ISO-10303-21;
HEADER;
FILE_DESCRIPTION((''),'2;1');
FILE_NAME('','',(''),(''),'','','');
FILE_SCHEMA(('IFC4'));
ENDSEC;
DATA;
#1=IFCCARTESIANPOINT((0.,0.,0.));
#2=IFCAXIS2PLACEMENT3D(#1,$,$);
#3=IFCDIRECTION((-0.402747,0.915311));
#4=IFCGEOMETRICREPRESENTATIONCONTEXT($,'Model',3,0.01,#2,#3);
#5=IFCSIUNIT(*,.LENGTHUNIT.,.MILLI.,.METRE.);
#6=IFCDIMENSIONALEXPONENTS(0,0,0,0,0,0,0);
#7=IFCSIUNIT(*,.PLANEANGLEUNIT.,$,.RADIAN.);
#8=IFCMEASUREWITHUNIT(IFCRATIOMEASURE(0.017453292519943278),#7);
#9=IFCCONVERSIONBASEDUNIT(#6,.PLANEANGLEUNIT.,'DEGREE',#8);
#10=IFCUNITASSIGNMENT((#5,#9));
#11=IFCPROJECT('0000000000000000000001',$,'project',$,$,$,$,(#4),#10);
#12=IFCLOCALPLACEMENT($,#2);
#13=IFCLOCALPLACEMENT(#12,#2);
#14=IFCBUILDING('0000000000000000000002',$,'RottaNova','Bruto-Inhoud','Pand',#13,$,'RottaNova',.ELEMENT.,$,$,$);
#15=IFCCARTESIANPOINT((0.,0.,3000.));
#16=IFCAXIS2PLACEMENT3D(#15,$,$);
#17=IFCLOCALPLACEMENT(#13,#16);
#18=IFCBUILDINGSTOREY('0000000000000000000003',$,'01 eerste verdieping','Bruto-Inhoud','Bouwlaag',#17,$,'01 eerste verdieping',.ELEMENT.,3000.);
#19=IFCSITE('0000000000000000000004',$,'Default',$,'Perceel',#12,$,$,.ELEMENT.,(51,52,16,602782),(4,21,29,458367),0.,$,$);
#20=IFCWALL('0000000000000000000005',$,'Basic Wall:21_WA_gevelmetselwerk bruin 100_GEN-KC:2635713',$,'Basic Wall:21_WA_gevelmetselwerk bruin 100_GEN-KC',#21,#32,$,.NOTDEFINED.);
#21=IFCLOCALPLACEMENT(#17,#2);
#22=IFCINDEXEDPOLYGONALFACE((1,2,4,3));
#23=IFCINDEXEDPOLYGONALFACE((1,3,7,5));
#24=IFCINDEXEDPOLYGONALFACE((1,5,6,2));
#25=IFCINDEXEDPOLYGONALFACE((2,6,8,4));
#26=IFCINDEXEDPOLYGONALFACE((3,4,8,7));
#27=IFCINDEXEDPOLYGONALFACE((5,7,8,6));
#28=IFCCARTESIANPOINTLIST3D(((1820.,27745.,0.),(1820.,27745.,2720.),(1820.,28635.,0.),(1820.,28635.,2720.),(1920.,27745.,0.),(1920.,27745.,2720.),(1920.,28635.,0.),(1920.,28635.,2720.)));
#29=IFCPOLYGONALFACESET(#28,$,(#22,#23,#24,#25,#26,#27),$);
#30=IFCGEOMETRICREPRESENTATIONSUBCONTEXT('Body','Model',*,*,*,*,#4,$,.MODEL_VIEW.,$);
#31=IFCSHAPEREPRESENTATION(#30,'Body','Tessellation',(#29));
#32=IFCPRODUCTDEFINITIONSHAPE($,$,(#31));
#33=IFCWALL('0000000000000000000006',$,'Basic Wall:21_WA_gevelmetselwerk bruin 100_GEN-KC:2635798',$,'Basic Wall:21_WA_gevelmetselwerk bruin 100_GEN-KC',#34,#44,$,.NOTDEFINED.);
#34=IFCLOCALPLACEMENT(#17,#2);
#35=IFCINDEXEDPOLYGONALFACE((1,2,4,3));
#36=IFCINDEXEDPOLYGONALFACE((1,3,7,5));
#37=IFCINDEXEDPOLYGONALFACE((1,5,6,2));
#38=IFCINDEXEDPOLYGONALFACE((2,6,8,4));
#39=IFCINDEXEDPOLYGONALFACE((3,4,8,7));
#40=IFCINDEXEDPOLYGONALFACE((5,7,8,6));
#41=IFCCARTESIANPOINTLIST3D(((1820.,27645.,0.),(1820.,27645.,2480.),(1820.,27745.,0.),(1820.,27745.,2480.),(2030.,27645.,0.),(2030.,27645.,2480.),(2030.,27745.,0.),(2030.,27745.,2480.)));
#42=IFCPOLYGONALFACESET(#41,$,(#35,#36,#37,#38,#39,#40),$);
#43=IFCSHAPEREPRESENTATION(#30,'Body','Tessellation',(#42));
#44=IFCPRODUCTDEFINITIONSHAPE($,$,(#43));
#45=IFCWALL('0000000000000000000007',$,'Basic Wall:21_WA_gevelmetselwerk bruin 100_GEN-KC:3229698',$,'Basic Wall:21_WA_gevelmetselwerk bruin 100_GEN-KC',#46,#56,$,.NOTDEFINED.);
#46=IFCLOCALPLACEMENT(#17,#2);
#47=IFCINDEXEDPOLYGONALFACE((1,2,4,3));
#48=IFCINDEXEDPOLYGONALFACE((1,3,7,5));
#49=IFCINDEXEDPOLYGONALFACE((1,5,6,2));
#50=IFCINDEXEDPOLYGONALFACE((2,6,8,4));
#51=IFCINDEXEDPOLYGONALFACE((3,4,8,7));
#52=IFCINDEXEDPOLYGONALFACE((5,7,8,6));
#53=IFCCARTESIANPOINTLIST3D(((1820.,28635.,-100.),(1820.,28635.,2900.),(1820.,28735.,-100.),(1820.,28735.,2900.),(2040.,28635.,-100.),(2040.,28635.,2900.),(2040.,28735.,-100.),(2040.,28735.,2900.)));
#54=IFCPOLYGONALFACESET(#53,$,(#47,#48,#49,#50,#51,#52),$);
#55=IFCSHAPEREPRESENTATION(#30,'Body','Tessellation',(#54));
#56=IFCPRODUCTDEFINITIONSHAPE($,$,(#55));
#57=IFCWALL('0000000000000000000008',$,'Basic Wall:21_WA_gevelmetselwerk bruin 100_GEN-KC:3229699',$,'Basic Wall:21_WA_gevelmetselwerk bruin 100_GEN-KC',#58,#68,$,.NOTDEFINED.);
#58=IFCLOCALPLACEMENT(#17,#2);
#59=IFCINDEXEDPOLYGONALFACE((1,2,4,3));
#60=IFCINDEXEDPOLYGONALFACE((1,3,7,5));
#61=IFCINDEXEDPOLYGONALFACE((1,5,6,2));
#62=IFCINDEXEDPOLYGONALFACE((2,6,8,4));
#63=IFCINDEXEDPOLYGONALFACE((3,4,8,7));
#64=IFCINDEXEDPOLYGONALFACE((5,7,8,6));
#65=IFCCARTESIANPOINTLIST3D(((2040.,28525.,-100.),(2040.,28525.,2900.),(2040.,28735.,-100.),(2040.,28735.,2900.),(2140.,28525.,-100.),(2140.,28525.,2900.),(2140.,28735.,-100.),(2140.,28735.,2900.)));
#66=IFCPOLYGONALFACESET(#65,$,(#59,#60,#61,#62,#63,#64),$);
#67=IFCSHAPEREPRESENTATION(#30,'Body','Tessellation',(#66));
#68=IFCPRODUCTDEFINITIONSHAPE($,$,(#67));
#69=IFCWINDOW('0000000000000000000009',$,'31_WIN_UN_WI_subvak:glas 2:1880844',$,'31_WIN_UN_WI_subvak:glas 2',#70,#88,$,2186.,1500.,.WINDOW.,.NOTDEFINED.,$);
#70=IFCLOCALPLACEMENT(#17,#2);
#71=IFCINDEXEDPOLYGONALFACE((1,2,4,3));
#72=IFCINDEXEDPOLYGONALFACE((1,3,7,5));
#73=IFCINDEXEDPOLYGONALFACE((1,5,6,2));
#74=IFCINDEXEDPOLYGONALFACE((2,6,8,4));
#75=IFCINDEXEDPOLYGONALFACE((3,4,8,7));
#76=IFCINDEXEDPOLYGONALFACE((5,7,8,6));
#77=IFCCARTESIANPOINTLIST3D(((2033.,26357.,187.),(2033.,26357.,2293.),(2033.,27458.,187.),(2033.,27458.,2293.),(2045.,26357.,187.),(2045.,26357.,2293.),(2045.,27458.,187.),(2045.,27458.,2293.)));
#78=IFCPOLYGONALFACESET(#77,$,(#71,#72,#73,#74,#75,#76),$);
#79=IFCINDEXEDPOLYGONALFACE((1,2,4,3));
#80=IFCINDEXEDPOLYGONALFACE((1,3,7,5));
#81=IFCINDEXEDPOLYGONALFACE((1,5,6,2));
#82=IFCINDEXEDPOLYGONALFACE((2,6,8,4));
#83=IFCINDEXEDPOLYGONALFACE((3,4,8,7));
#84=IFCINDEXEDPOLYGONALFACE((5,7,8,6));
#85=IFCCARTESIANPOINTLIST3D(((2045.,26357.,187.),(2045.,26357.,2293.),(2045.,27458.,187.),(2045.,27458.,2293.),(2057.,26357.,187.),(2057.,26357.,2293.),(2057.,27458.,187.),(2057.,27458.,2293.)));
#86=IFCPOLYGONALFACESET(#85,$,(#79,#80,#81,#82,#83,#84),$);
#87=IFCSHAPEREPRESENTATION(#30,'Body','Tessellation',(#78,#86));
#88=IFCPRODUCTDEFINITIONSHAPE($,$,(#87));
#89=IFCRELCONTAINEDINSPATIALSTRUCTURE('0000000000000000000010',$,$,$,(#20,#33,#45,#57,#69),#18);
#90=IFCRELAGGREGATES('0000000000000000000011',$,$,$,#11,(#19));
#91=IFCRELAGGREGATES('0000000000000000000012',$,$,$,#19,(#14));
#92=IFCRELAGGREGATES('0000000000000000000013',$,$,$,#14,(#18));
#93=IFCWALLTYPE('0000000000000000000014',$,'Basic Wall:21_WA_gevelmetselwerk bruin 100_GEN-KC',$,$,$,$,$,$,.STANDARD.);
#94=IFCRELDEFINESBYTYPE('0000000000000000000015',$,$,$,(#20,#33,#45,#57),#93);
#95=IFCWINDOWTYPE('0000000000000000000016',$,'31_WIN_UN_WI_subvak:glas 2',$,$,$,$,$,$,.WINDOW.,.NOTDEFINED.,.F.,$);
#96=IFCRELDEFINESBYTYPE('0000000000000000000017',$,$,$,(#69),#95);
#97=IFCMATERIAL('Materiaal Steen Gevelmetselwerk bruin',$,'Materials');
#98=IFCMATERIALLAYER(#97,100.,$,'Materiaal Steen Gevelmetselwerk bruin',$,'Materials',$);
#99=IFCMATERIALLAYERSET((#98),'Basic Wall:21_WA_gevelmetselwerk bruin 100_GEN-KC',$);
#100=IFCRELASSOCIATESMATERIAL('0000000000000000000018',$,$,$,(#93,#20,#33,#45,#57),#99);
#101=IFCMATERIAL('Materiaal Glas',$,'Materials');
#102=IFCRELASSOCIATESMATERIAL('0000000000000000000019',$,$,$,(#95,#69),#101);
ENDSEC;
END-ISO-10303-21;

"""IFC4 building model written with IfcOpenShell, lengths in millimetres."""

from ifc_helpers import new_model, entity, si_unit, converted_unit, direction, frame, frame_2d, origin, origin_2d_with_axis, place, context, subcontext, project, spatial, rectangle, extrude, source, transform, mapped, material, layer, layer_set, type_object, type_shapes, element, save


model = new_model("IFC4")

# Units and contexts
model_context = context("Model", 3, precision=0.01, world=origin(), true_north=direction((-0.402747, 0.915311)))
body_context = subcontext(model_context, "Body", "Model", "MODEL_VIEW")
ifc_project = project(units=[si_unit("LENGTHUNIT", "METRE", prefix="MILLI"), converted_unit("PLANEANGLEUNIT", "DEGREE", entity("IfcRatioMeasure", 0.017453292519943278), si_unit("PLANEANGLEUNIT", "RADIAN"), dimensions=[0, 0, 0, 0, 0, 0, 0])], contexts=[model_context])

# Site, building, storey
site_placement = place(None, origin())
site = spatial("IfcSite", under=ifc_project, at=site_placement, Name="Default", ObjectType="Perceel", CompositionType="ELEMENT", RefLatitude=(51, 52, 16, 602782), RefLongitude=(4, 21, 29, 458367), RefElevation=0.0)
building_placement = place(site_placement, origin())
building = spatial("IfcBuilding", under=site, at=building_placement, Name="RottaNova", Description="Bruto-Inhoud", ObjectType="Pand", LongName="RottaNova", CompositionType="ELEMENT")
storey_placement = place(building_placement, frame((0.0, 0.0, 3000.0)))
storey = spatial("IfcBuildingStorey", under=building, at=storey_placement, Name="01 eerste verdieping", Description="Bruto-Inhoud", ObjectType="Bouwlaag", LongName="01 eerste verdieping", CompositionType="ELEMENT", Elevation=3000.0)

# Walls
ifc_material_1 = material(Name="Materiaal Steen Gevelmetselwerk bruin", Category="Materials")
ifc_layer_1 = layer(ifc_material_1, 100.0, Name="Materiaal Steen Gevelmetselwerk bruin", Category="Materials")
ifc_layer_set_1 = layer_set([ifc_layer_1], Name="Basic Wall:21_WA_gevelmetselwerk bruin 100_GEN-KC")
wall_type_1 = type_object("IfcWallType", Name="Basic Wall:21_WA_gevelmetselwerk bruin 100_GEN-KC", PredefinedType="STANDARD", material=ifc_layer_set_1)
wall_1_placement = place(storey_placement, frame((1870.0, 27745.0, 0.0), z_axis=(0.0, 0.0, 1.0), x_axis=(0.0, 1.0, 0.0)))
element("IfcWall", 1, at=wall_1_placement, inside=storey, type_object=wall_type_1, material=ifc_layer_set_1, Name="Basic Wall:21_WA_gevelmetselwerk bruin 100_GEN-KC:2635713", ObjectType="Basic Wall:21_WA_gevelmetselwerk bruin 100_GEN-KC", PredefinedType="NOTDEFINED", context=body_context, shape_type="SweptSolid", body=[
    extrude(rectangle(XDim=890.0, YDim=100.0, at=frame_2d((445.0, 0.0), x_axis=(-1.0, 0.0))), origin(), (0.0, 0.0, 1.0), 2720.0),
])
wall_2_placement = place(storey_placement, frame((2030.0, 27695.0, 0.0), z_axis=(0.0, 0.0, 1.0), x_axis=(-1.0, 0.0, 0.0)))
element("IfcWall", 2, at=wall_2_placement, inside=storey, type_object=wall_type_1, material=ifc_layer_set_1, Name="Basic Wall:21_WA_gevelmetselwerk bruin 100_GEN-KC:2635798", ObjectType="Basic Wall:21_WA_gevelmetselwerk bruin 100_GEN-KC", PredefinedType="NOTDEFINED", context=body_context, shape_type="SweptSolid", body=[
    extrude(rectangle(XDim=210.0, YDim=100.0, at=frame_2d((105.0, 0.0), x_axis=(-1.0, 0.0))), origin(), (0.0, 0.0, 1.0), 2480.0),
])
wall_3_placement = place(storey_placement, frame((2040.0, 28685.0, -100.0), z_axis=(0.0, 0.0, 1.0), x_axis=(-1.0, 0.0, 0.0)))
element("IfcWall", 3, at=wall_3_placement, inside=storey, type_object=wall_type_1, material=ifc_layer_set_1, Name="Basic Wall:21_WA_gevelmetselwerk bruin 100_GEN-KC:3229698", ObjectType="Basic Wall:21_WA_gevelmetselwerk bruin 100_GEN-KC", PredefinedType="NOTDEFINED", context=body_context, shape_type="SweptSolid", body=[
    extrude(rectangle(XDim=220.0, YDim=100.0, at=frame_2d((110.0, 0.0), x_axis=(-1.0, 0.0))), origin(), (0.0, 0.0, 1.0), 3000.0),
])
wall_4_placement = place(storey_placement, frame((2090.0, 28735.0, -100.0), z_axis=(0.0, 0.0, 1.0), x_axis=(0.0, -1.0, 0.0)))
element("IfcWall", 4, at=wall_4_placement, inside=storey, type_object=wall_type_1, material=ifc_layer_set_1, Name="Basic Wall:21_WA_gevelmetselwerk bruin 100_GEN-KC:3229699", ObjectType="Basic Wall:21_WA_gevelmetselwerk bruin 100_GEN-KC", PredefinedType="NOTDEFINED", context=body_context, shape_type="SweptSolid", body=[
    extrude(rectangle(XDim=210.0, YDim=100.0, at=frame_2d((105.0, 0.0), x_axis=(-1.0, 0.0))), origin(), (0.0, 0.0, 1.0), 3000.0),
])

# Window
ifc_material_2 = material(Name="Materiaal Glas", Category="Materials")
window_type = type_object("IfcWindowType", Name="31_WIN_UN_WI_subvak:glas 2", ParameterTakesPrecedence=False, PartitioningType="NOTDEFINED", PredefinedType="WINDOW", material=ifc_material_2)
shared_shape_1 = source(origin(), body_context, "Body", "SweptSolid", [
    extrude(rectangle(XDim=1101.0, YDim=12.0, at=origin_2d_with_axis()), frame((0.0, -6.0, 0.0)), (0.0, 0.0, 1.0), 2106.0),
    extrude(rectangle(XDim=1101.0, YDim=12.0, at=origin_2d_with_axis()), frame((0.0, 6.0, 0.0)), (0.0, 0.0, 1.0), 2106.0),
])
type_shapes(window_type, [shared_shape_1])
window_placement = place(storey_placement, frame((2045.0, 26907.5, 187.0), z_axis=(0.0, 0.0, 1.0), x_axis=(0.0, -1.0, 0.0)))
element("IfcWindow", 5, at=window_placement, inside=storey, type_object=window_type, material=ifc_material_2, Name="31_WIN_UN_WI_subvak:glas 2:1880844", ObjectType="31_WIN_UN_WI_subvak:glas 2", OverallHeight=2186.0, OverallWidth=1500.0, PartitioningType="NOTDEFINED", PredefinedType="WINDOW", context=body_context, shape_type="MappedRepresentation", body=[
    mapped(shared_shape_1, transform((0.0, 0.0, 0.0), scale=1.0)),
])

save(model, "model.ifc")
